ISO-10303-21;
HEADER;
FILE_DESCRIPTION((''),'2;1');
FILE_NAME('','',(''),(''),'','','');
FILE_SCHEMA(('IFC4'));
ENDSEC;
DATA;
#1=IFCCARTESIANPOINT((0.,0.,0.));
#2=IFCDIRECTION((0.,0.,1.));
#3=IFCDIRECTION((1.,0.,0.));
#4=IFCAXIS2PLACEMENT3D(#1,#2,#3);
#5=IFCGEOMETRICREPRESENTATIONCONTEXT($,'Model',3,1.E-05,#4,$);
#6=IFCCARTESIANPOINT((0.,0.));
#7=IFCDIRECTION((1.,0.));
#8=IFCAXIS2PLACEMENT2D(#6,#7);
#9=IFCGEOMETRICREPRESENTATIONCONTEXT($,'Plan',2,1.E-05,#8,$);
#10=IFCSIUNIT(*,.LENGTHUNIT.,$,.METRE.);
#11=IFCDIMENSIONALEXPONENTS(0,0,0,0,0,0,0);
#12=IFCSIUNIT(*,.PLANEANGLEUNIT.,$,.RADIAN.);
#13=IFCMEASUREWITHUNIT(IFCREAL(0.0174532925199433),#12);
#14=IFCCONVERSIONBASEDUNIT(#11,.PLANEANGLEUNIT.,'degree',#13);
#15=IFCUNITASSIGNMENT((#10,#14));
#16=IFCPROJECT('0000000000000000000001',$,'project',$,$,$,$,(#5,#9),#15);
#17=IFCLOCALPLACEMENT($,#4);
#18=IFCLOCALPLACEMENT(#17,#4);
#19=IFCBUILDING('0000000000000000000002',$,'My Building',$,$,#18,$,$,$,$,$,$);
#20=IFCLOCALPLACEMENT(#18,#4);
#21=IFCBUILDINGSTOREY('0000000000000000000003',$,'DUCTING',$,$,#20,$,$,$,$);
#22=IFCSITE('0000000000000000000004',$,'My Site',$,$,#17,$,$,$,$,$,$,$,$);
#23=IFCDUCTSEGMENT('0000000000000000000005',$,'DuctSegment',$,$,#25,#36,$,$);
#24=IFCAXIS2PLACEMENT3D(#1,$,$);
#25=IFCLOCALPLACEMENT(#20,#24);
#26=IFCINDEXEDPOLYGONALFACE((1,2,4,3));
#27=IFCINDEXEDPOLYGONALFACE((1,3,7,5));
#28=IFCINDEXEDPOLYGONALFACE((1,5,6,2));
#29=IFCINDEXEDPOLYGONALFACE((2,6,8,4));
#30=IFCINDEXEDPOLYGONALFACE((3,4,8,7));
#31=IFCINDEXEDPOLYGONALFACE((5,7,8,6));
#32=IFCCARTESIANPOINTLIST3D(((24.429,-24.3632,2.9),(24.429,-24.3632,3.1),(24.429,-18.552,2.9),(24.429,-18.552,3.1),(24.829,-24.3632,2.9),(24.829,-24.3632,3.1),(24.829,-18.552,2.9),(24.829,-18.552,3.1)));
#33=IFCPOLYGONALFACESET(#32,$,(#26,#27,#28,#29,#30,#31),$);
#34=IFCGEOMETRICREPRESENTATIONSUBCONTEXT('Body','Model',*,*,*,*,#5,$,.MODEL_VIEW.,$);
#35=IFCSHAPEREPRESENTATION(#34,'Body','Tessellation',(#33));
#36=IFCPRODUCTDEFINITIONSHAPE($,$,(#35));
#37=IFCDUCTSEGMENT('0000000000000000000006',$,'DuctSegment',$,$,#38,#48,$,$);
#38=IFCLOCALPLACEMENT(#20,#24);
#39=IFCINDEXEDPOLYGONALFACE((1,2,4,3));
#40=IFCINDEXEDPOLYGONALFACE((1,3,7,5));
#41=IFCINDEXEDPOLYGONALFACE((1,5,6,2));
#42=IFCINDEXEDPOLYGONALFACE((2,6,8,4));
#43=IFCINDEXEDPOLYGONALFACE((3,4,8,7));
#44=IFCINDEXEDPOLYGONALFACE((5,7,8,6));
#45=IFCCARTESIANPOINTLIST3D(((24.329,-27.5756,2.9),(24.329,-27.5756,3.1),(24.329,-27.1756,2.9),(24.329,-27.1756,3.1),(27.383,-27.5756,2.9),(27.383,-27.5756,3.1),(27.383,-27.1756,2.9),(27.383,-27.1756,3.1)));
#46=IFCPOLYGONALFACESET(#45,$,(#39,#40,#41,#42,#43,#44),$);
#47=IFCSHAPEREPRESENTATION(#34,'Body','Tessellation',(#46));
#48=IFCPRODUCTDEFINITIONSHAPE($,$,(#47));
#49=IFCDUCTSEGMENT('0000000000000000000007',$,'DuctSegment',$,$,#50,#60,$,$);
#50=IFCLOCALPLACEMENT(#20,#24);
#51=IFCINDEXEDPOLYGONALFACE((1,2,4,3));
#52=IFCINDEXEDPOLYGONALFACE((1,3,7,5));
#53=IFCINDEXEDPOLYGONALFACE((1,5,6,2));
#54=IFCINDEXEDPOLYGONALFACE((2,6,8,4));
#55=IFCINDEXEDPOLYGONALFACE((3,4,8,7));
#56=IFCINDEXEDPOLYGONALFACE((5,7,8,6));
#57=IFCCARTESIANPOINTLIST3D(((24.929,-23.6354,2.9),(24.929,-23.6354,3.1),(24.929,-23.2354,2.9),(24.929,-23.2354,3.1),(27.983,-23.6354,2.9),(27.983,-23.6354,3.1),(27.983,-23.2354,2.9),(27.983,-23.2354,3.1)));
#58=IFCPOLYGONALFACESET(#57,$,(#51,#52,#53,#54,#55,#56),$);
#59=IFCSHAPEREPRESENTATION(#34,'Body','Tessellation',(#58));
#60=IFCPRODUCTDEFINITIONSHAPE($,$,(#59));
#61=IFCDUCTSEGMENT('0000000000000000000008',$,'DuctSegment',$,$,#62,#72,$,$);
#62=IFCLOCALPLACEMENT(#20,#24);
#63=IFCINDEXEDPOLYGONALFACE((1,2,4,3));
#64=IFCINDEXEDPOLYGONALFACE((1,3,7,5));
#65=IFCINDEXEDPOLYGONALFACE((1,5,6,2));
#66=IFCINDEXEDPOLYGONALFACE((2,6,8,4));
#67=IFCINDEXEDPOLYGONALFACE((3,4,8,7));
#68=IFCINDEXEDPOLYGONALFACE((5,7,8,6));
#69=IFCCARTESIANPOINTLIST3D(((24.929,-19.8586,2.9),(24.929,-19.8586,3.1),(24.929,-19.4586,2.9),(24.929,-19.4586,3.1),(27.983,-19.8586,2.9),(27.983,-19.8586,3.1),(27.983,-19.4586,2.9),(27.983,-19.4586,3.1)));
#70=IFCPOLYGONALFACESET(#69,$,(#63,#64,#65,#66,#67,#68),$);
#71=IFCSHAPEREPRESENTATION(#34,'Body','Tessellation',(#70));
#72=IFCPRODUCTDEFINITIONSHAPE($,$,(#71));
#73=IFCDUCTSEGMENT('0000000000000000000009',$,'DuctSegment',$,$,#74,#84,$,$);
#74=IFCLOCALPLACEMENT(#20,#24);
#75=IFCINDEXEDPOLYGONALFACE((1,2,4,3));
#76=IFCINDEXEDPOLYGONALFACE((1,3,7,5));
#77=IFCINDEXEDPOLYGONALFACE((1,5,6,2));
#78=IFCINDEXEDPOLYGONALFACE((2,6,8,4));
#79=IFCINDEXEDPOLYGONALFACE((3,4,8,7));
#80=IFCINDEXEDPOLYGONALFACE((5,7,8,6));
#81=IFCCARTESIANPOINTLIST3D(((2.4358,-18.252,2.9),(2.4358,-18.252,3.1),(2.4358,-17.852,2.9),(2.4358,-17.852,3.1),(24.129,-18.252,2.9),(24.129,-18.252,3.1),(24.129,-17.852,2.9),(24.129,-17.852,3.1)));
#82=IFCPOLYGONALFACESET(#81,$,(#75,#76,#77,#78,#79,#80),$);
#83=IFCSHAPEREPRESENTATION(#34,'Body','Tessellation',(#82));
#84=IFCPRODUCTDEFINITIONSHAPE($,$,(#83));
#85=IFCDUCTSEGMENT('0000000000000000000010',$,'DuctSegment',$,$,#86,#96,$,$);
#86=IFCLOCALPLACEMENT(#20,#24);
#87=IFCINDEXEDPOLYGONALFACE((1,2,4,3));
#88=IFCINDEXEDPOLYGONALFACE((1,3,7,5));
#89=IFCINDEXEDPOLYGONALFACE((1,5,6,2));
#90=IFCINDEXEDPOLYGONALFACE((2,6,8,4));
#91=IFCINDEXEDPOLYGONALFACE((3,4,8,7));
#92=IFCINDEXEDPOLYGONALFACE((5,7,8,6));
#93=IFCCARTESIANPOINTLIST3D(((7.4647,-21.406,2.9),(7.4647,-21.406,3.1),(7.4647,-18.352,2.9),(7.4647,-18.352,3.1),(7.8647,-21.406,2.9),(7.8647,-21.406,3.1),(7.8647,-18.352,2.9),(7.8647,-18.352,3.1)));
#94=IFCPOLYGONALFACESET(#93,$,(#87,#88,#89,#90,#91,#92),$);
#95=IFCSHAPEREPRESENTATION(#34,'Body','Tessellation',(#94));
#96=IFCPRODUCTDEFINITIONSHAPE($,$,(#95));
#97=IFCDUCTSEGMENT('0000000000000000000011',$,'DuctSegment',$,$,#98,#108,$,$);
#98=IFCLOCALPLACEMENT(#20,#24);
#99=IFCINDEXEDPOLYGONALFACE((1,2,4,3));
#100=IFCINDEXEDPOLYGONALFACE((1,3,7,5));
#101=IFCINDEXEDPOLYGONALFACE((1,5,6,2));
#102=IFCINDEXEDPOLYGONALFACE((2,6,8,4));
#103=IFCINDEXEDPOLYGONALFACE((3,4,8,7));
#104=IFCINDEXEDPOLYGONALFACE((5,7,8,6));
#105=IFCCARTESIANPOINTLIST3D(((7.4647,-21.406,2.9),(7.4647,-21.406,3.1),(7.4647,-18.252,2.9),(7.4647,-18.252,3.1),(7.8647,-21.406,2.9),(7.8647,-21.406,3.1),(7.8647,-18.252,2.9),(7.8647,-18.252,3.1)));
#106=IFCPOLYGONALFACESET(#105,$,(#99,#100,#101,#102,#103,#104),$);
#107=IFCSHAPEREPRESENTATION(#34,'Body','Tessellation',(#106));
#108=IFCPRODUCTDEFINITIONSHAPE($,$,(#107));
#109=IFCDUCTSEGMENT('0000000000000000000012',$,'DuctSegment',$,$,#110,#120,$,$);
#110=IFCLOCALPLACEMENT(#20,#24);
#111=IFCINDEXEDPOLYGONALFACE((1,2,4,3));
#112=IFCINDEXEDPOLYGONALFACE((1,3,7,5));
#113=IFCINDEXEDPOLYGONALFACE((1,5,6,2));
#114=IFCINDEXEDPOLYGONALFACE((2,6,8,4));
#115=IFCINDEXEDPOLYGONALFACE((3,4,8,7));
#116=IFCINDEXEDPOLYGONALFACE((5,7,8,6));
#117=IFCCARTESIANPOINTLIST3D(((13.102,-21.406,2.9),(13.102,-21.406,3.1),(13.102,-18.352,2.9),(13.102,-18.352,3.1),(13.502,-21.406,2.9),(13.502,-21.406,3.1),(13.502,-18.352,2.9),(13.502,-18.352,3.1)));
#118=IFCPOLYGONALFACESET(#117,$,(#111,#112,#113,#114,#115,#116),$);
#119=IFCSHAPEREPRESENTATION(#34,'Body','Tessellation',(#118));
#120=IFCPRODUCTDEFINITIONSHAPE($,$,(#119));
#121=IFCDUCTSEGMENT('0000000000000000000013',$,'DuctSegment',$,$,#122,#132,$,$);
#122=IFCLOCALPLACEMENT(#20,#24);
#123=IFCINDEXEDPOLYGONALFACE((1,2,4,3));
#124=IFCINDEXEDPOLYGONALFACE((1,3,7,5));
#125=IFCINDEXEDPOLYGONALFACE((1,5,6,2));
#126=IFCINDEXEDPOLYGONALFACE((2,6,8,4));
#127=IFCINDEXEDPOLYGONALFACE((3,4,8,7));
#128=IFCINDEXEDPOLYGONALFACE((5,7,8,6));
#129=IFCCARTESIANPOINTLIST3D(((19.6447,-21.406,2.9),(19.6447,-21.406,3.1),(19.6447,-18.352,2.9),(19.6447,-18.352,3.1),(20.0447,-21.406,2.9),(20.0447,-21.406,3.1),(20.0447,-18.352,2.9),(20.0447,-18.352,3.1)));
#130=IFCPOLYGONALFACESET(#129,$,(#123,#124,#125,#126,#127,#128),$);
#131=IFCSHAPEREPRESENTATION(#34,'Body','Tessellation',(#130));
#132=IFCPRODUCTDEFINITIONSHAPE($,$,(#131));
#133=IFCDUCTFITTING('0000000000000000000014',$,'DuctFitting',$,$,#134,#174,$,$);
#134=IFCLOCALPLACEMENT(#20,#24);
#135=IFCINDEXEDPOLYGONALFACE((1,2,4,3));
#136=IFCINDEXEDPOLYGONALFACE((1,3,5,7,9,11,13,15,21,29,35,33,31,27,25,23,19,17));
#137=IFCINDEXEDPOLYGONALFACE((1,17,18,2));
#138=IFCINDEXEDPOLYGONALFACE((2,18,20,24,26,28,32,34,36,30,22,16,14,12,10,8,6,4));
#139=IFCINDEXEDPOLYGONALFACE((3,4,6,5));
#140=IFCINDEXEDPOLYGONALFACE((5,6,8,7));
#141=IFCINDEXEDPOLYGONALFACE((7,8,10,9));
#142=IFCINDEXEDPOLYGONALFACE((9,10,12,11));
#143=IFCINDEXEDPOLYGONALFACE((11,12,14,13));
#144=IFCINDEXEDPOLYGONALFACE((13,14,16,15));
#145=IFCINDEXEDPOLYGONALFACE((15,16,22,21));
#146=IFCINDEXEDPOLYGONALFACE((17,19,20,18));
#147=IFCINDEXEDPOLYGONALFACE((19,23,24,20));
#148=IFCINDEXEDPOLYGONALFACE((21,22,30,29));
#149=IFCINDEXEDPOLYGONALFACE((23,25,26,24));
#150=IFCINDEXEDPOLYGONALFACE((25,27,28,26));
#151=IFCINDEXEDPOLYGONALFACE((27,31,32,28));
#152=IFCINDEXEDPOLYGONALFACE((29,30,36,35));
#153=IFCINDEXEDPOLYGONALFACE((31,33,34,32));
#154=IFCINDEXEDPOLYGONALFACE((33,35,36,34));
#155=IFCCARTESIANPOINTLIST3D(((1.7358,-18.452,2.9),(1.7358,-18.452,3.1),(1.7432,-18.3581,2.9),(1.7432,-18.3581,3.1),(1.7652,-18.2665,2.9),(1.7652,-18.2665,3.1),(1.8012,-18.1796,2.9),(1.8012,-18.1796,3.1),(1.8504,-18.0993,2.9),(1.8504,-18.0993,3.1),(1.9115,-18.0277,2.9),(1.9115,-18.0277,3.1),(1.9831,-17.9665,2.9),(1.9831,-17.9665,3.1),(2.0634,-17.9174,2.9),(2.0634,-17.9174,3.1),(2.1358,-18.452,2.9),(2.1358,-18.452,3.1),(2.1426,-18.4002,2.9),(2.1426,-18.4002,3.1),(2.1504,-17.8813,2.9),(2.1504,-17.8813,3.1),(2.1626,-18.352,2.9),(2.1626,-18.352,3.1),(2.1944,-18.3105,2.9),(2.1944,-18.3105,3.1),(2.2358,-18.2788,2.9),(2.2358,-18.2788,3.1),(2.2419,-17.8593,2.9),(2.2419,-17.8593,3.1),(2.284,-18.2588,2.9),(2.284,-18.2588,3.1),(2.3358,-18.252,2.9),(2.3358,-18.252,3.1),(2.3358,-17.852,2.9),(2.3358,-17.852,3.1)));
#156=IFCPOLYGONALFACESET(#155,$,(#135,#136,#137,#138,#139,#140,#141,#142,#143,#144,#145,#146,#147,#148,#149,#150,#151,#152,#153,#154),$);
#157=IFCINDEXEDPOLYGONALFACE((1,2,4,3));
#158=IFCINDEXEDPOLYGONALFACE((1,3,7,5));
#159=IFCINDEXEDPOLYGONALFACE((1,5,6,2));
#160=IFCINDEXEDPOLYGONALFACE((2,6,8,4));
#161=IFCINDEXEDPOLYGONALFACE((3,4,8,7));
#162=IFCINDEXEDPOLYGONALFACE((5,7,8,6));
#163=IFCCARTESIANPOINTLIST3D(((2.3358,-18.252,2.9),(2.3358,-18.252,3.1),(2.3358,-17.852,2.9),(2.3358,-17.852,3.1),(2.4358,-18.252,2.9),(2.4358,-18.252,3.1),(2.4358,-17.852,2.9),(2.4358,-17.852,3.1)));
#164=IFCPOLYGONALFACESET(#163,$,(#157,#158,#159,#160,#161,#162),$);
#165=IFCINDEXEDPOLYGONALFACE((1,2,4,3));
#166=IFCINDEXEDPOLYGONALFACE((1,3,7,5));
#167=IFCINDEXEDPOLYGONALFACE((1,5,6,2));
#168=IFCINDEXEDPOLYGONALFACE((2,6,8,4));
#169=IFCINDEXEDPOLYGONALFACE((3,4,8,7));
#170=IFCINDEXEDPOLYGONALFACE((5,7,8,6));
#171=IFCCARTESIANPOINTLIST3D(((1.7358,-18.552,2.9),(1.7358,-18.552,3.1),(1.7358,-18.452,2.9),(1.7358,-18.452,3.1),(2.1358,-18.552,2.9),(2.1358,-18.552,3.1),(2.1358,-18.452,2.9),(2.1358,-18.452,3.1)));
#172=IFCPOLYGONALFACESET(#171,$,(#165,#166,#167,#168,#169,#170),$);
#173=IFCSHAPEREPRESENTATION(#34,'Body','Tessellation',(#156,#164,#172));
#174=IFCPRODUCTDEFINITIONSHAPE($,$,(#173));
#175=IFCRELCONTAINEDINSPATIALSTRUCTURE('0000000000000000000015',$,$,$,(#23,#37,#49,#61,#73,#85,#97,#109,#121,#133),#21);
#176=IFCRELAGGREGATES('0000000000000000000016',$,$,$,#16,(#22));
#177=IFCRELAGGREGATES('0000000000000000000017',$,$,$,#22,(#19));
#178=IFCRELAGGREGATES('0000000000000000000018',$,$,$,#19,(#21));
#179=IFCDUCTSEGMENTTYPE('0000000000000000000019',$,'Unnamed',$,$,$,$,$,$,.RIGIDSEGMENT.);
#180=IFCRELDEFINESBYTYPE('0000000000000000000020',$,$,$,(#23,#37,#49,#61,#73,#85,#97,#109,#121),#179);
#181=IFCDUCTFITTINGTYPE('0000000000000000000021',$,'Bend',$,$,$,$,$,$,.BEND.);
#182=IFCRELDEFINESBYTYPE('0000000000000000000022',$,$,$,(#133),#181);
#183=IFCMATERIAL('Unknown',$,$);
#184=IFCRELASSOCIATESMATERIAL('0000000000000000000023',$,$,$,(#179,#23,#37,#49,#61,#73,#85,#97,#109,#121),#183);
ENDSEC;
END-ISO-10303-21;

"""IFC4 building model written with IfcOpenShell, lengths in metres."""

from ifc_helpers import new_model, entity, si_unit, converted_unit, frame, origin_with_axes, origin_2d_with_axis, place, context, subcontext, project, spatial, line, arc, indexed_curve, rectangle, outline, extrude, source, transform, mapped, material, material_profile, profile_set, profile_usage, type_object, type_shapes, element, save


model = new_model("IFC4")

# Units and contexts
model_context = context("Model", 3, precision=1e-05, world=origin_with_axes())
plan_context = context("Plan", 2, precision=1e-05, world=origin_2d_with_axis())
body_context = subcontext(model_context, "Body", "Model", "MODEL_VIEW")
ifc_project = project(units=[si_unit("LENGTHUNIT", "METRE"), converted_unit("PLANEANGLEUNIT", "degree", entity("IfcReal", 0.0174532925199433), si_unit("PLANEANGLEUNIT", "RADIAN"), dimensions=[0, 0, 0, 0, 0, 0, 0])], contexts=[model_context, plan_context])

# Site, building, storey
site_placement = place(None, origin_with_axes())
site = spatial("IfcSite", under=ifc_project, at=site_placement, Name="My Site")
building_placement = place(site_placement, origin_with_axes())
building = spatial("IfcBuilding", under=site, at=building_placement, Name="My Building")
storey_placement = place(building_placement, origin_with_axes())
storey = spatial("IfcBuildingStorey", under=building, at=storey_placement, Name="DUCTING")

# Duct segments
ifc_material = material(Name="Unknown")
ifc_material_profile = material_profile(ifc_material, rectangle(XDim=0.4, YDim=0.2))
ifc_profile_set = profile_set([ifc_material_profile])
duct_segment_type = type_object("IfcDuctSegmentType", Name="Unnamed", PredefinedType="RIGIDSEGMENT", material=ifc_profile_set)
ifc_profile_usage_1 = profile_usage(ifc_profile_set, cardinal=5)
duct_segment_1_placement = place(storey_placement, frame((24.629, -18.552, 3.0), z_axis=(0.0, -1.0, 0.0), x_axis=(1.0, 0.0, 0.0)))
element("IfcDuctSegment", 1, at=duct_segment_1_placement, inside=storey, type_object=duct_segment_type, material=ifc_profile_usage_1, Name="DuctSegment", context=body_context, shape_type="SweptSolid", body=[
    extrude(rectangle(XDim=0.4, YDim=0.2), origin_with_axes(), (0.0, 0.0, 1.0), 5.8113),
])
ifc_profile_usage_2 = profile_usage(ifc_profile_set, cardinal=5)
duct_segment_2_placement = place(storey_placement, frame((24.329, -27.3756, 3.0), z_axis=(1.0, 0.0, 0.0), x_axis=(0.0, 1.0, 0.0)))
element("IfcDuctSegment", 2, at=duct_segment_2_placement, inside=storey, type_object=duct_segment_type, material=ifc_profile_usage_2, Name="DuctSegment", context=body_context, shape_type="SweptSolid", body=[
    extrude(rectangle(XDim=0.4, YDim=0.2), origin_with_axes(), (0.0, 0.0, 1.0), 3.054),
])
ifc_profile_usage_3 = profile_usage(ifc_profile_set, cardinal=5)
duct_segment_3_placement = place(storey_placement, frame((24.929, -23.4354, 3.0), z_axis=(1.0, 0.0, 0.0), x_axis=(0.0, 1.0, 0.0)))
element("IfcDuctSegment", 3, at=duct_segment_3_placement, inside=storey, type_object=duct_segment_type, material=ifc_profile_usage_3, Name="DuctSegment", context=body_context, shape_type="SweptSolid", body=[
    extrude(rectangle(XDim=0.4, YDim=0.2), origin_with_axes(), (0.0, 0.0, 1.0), 3.054),
])
ifc_profile_usage_4 = profile_usage(ifc_profile_set, cardinal=5)
duct_segment_4_placement = place(storey_placement, frame((24.929, -19.6586, 3.0), z_axis=(1.0, 0.0, 0.0), x_axis=(0.0, 1.0, 0.0)))
element("IfcDuctSegment", 4, at=duct_segment_4_placement, inside=storey, type_object=duct_segment_type, material=ifc_profile_usage_4, Name="DuctSegment", context=body_context, shape_type="SweptSolid", body=[
    extrude(rectangle(XDim=0.4, YDim=0.2), origin_with_axes(), (0.0, 0.0, 1.0), 3.054),
])
ifc_profile_usage_5 = profile_usage(ifc_profile_set, cardinal=5)
duct_segment_5_placement = place(storey_placement, frame((2.4358, -18.052, 3.0), z_axis=(1.0, 0.0, 0.0), x_axis=(0.0, 1.0, 0.0)))
element("IfcDuctSegment", 5, at=duct_segment_5_placement, inside=storey, type_object=duct_segment_type, material=ifc_profile_usage_5, Name="DuctSegment", context=body_context, shape_type="SweptSolid", body=[
    extrude(rectangle(XDim=0.4, YDim=0.2), origin_with_axes(), (0.0, 0.0, 1.0), 21.6932),
])
ifc_profile_usage_6 = profile_usage(ifc_profile_set, cardinal=5)
duct_segment_6_placement = place(storey_placement, frame((7.6647, -18.352, 3.0), z_axis=(0.0, -1.0, 0.0), x_axis=(1.0, 0.0, 0.0)))
element("IfcDuctSegment", 6, at=duct_segment_6_placement, inside=storey, type_object=duct_segment_type, material=ifc_profile_usage_6, Name="DuctSegment", context=body_context, shape_type="SweptSolid", body=[
    extrude(rectangle(XDim=0.4, YDim=0.2), origin_with_axes(), (0.0, 0.0, 1.0), 3.054),
])
ifc_profile_usage_7 = profile_usage(ifc_profile_set, cardinal=5)
duct_segment_7_placement = place(storey_placement, frame((7.6647, -18.252, 3.0), z_axis=(0.0, -1.0, 0.0), x_axis=(1.0, 0.0, 0.0)))
element("IfcDuctSegment", 7, at=duct_segment_7_placement, inside=storey, type_object=duct_segment_type, material=ifc_profile_usage_7, Name="DuctSegment", context=body_context, shape_type="SweptSolid", body=[
    extrude(rectangle(XDim=0.4, YDim=0.2), origin_with_axes(), (0.0, 0.0, 1.0), 3.154),
])
ifc_profile_usage_8 = profile_usage(ifc_profile_set, cardinal=5)
duct_segment_8_placement = place(storey_placement, frame((13.302, -18.352, 3.0), z_axis=(0.0, -1.0, 0.0), x_axis=(1.0, 0.0, 0.0)))
element("IfcDuctSegment", 8, at=duct_segment_8_placement, inside=storey, type_object=duct_segment_type, material=ifc_profile_usage_8, Name="DuctSegment", context=body_context, shape_type="SweptSolid", body=[
    extrude(rectangle(XDim=0.4, YDim=0.2), origin_with_axes(), (0.0, 0.0, 1.0), 3.054),
])
ifc_profile_usage_9 = profile_usage(ifc_profile_set, cardinal=5)
duct_segment_9_placement = place(storey_placement, frame((19.8447, -18.352, 3.0), z_axis=(0.0, -1.0, 0.0), x_axis=(1.0, 0.0, 0.0)))
element("IfcDuctSegment", 9, at=duct_segment_9_placement, inside=storey, type_object=duct_segment_type, material=ifc_profile_usage_9, Name="DuctSegment", context=body_context, shape_type="SweptSolid", body=[
    extrude(rectangle(XDim=0.4, YDim=0.2), origin_with_axes(), (0.0, 0.0, 1.0), 3.054),
])

# Duct fitting
duct_fitting_type = type_object("IfcDuctFittingType", Name="Bend", PredefinedType="BEND")
shared_shape = source(origin_with_axes(), body_context, "Body", "SweptSolid", [
    extrude(outline(indexed_curve([(-0.2, 0.0), (-0.2586, -0.1414), (-0.4, -0.2), (-0.4, -0.6), (0.0243, -0.4243), (0.2, 0.0)], segments=[arc(1, 2, 3), line(3, 4), arc(4, 5, 6), line(6, 1)])), frame((0.0, -0.1, -0.1), z_axis=(0.0, -1.0, 0.0), x_axis=(1.0, 0.0, 0.0)), (0.0, 0.0, -1.0), 0.2),
    extrude(rectangle(XDim=0.4, YDim=0.2), origin_with_axes(), (0.0, 0.0, -1.0), 0.1),
    extrude(rectangle(XDim=0.4, YDim=0.2), frame((-0.4, 0.0, -0.5), z_axis=(-1.0, 0.0, 0.0), x_axis=(0.0, 0.0, -1.0)), (0.0, 0.0, 1.0), 0.1),
])
type_shapes(duct_fitting_type, [shared_shape])
for number, where, z_axis, x_axis, name in (
    (10, (2.4358, -18.052, 3.0), (1.0, 0.0, 0.0), (0.0, 1.0, 0.0), "DuctFitting"),
):
    element("IfcDuctFitting", number, at=place(storey_placement, frame(where, z_axis=z_axis, x_axis=x_axis)), inside=storey, type_object=duct_fitting_type, Name=name, context=body_context, shape_type="MappedRepresentation", body=[
        mapped(shared_shape, transform((0.0, 0.0, 0.0), x_axis=(1.0, 0.0, 0.0), y_axis=(0.0, 1.0, 0.0), z_axis=(0.0, 0.0, 1.0), scale=1.0)),
    ])

save(model, "model.ifc")
